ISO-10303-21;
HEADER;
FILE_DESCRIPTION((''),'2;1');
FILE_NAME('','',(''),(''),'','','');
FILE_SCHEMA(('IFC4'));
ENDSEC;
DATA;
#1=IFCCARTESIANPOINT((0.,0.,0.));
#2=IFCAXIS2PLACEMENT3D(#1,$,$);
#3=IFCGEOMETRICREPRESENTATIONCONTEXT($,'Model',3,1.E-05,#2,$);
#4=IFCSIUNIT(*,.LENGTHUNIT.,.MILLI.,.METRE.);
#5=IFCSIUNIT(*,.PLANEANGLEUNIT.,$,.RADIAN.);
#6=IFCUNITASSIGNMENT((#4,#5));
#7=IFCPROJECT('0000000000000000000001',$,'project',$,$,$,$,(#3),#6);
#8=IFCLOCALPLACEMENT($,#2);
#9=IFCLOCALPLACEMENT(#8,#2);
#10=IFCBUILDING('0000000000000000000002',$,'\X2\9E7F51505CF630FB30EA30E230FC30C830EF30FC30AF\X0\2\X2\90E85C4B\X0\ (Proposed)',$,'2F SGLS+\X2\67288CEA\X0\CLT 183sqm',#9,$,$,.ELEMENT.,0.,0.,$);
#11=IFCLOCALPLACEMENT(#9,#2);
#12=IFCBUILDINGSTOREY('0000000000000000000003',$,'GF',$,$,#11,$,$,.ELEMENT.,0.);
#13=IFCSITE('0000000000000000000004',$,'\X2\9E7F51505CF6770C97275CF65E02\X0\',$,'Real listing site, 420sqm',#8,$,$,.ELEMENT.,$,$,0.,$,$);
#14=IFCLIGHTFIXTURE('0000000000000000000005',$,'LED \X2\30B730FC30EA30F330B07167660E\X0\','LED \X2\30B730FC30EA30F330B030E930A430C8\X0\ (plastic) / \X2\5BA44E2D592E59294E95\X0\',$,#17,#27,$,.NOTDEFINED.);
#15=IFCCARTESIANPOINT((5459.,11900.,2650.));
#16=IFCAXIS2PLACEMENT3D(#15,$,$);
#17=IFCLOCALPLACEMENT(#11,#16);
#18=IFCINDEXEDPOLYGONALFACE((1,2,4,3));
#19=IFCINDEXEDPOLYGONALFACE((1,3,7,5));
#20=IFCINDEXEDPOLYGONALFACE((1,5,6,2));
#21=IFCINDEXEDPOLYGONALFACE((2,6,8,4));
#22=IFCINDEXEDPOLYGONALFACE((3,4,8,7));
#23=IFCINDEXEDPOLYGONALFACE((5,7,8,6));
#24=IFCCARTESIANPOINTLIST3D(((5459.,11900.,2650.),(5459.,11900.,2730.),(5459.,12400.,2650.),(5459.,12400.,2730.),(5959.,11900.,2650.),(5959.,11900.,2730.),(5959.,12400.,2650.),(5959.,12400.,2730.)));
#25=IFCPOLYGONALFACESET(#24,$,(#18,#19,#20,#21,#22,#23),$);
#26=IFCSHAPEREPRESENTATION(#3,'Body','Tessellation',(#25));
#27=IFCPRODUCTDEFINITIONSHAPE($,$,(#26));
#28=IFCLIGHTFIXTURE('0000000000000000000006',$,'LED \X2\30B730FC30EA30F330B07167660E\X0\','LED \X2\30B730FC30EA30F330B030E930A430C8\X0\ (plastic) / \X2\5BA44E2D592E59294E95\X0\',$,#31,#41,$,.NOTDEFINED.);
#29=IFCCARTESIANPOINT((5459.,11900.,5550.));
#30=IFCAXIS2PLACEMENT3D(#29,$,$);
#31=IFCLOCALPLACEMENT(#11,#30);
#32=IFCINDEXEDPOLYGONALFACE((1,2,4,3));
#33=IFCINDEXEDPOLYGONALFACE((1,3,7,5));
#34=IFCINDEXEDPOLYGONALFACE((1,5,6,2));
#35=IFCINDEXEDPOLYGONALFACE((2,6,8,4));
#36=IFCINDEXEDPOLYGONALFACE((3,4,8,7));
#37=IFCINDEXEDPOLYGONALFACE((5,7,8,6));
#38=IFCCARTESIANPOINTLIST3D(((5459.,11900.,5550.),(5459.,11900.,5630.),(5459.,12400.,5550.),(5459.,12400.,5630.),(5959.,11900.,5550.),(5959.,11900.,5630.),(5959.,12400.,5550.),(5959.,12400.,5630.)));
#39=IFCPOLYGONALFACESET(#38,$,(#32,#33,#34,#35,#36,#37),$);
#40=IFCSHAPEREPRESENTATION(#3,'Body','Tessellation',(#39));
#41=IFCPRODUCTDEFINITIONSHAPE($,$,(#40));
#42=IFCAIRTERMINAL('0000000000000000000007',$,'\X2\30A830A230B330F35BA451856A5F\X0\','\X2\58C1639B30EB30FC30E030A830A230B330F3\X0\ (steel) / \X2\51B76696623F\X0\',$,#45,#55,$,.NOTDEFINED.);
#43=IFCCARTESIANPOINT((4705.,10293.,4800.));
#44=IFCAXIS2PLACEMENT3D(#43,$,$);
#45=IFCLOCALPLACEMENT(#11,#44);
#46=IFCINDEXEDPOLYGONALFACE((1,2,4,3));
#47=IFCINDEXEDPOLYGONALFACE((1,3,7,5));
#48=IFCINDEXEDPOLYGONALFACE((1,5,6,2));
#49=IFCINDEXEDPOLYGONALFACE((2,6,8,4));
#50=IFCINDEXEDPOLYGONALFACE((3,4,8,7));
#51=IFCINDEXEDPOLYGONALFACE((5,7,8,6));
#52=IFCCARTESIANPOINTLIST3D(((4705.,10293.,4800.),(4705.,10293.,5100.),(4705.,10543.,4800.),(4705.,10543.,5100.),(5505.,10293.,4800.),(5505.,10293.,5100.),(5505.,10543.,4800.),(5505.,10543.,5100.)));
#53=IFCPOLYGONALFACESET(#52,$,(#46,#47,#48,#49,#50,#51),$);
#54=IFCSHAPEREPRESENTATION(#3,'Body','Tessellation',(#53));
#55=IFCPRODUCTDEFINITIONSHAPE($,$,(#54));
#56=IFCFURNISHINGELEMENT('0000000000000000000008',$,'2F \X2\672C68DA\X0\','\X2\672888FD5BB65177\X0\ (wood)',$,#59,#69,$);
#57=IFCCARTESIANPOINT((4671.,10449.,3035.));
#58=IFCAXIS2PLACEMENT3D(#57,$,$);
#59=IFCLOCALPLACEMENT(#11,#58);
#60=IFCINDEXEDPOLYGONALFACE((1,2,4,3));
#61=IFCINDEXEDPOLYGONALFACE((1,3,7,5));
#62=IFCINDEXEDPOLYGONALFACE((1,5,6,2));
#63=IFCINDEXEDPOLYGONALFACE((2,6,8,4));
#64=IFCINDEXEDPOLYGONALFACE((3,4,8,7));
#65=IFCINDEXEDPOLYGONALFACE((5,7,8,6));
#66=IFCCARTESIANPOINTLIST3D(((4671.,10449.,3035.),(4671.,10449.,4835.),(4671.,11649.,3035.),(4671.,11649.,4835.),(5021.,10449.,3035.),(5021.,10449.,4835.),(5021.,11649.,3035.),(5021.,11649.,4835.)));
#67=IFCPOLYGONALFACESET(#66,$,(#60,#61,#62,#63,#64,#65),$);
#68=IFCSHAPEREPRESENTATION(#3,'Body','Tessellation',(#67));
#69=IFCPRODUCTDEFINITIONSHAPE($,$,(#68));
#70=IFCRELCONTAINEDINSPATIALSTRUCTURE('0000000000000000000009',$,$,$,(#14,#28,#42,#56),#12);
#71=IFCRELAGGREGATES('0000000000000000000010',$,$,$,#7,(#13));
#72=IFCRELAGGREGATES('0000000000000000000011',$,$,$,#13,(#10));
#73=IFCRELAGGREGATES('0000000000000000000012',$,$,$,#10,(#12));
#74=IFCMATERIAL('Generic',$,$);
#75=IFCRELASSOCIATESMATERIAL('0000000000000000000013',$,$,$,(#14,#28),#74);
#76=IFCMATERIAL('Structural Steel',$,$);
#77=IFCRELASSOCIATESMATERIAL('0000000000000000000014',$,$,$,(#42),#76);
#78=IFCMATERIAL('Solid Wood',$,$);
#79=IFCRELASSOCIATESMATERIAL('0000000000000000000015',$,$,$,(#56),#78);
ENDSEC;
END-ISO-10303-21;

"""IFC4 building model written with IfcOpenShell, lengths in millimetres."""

from ifc_helpers import new_model, si_unit, frame, frame_2d, origin, place, context, project, spatial, rectangle, extrude, material, element, save


model = new_model("IFC4")

# Units and contexts
model_context = context("Model", 3, precision=1e-05, world=origin())
ifc_project = project(units=[si_unit("LENGTHUNIT", "METRE", prefix="MILLI"), si_unit("PLANEANGLEUNIT", "RADIAN")], contexts=[model_context])

# Site, building, storey
site_placement = place(None, origin())
site = spatial("IfcSite", under=ifc_project, at=site_placement, Name="鹿児島県霧島市", ObjectType="Real listing site, 420sqm", CompositionType="ELEMENT", RefElevation=0.0)
building_placement = place(site_placement, origin())
building = spatial("IfcBuilding", under=site, at=building_placement, Name="鹿児島・リモートワーク2部屋 (Proposed)", ObjectType="2F SGLS+木質CLT 183sqm", CompositionType="ELEMENT", ElevationOfRefHeight=0.0, ElevationOfTerrain=0.0)
storey_placement = place(building_placement, origin())
storey = spatial("IfcBuildingStorey", under=building, at=storey_placement, Name="GF", CompositionType="ELEMENT", Elevation=0.0)

# Shared definitions
ifc_material_1 = material(Name="Solid Wood")

# Shared definitions
ifc_material_2 = material(Name="Structural Steel")

# Shared definitions
ifc_material_3 = material(Name="Generic")

# Light fixtures
light_fixture_1_placement = place(storey_placement, frame((5459.0, 11900.0, 2650.0)))
element("IfcLightFixture", 1, at=light_fixture_1_placement, inside=storey, material=ifc_material_3, Name="LED シーリング照明", Description="LED シーリングライト (plastic) / 室中央天井", PredefinedType="NOTDEFINED", context=model_context, shape_type="SweptSolid", body=[
    extrude(rectangle(XDim=500.0, YDim=500.0, at=frame_2d((250.0, 250.0))), frame((5459.0, 11900.0, 2650.0)), (0.0, 0.0, 1.0), 80.0),
])
light_fixture_2_placement = place(storey_placement, frame((5459.0, 11900.0, 5550.0)))
element("IfcLightFixture", 2, at=light_fixture_2_placement, inside=storey, material=ifc_material_3, Name="LED シーリング照明", Description="LED シーリングライト (plastic) / 室中央天井", PredefinedType="NOTDEFINED", context=model_context, shape_type="SweptSolid", body=[
    extrude(rectangle(XDim=500.0, YDim=500.0, at=frame_2d((250.0, 250.0))), frame((5459.0, 11900.0, 5550.0)), (0.0, 0.0, 1.0), 80.0),
])

# Air terminal
air_terminal_placement = place(storey_placement, frame((4705.0, 10293.0, 4800.0)))
element("IfcAirTerminal", 3, at=air_terminal_placement, inside=storey, material=ifc_material_2, Name="エアコン室内機", Description="壁掛ルームエアコン (steel) / 冷暖房", PredefinedType="NOTDEFINED", context=model_context, shape_type="SweptSolid", body=[
    extrude(rectangle(XDim=800.0, YDim=250.0, at=frame_2d((400.0, 125.0))), frame((4705.0, 10293.0, 4800.0)), (0.0, 0.0, 1.0), 300.0),
])

# Furnishing element
furnishing_placement = place(storey_placement, frame((4671.0, 10449.0, 3035.0)))
element("IfcFurnishingElement", 4, at=furnishing_placement, inside=storey, material=ifc_material_1, Name="2F 本棚", Description="木製家具 (wood)", context=model_context, shape_type="SweptSolid", body=[
    extrude(rectangle(XDim=350.0, YDim=1200.0, at=frame_2d((175.0, 600.0))), frame((4671.0, 10449.0, 3035.0)), (0.0, 0.0, 1.0), 1800.0),
])

save(model, "model.ifc")
